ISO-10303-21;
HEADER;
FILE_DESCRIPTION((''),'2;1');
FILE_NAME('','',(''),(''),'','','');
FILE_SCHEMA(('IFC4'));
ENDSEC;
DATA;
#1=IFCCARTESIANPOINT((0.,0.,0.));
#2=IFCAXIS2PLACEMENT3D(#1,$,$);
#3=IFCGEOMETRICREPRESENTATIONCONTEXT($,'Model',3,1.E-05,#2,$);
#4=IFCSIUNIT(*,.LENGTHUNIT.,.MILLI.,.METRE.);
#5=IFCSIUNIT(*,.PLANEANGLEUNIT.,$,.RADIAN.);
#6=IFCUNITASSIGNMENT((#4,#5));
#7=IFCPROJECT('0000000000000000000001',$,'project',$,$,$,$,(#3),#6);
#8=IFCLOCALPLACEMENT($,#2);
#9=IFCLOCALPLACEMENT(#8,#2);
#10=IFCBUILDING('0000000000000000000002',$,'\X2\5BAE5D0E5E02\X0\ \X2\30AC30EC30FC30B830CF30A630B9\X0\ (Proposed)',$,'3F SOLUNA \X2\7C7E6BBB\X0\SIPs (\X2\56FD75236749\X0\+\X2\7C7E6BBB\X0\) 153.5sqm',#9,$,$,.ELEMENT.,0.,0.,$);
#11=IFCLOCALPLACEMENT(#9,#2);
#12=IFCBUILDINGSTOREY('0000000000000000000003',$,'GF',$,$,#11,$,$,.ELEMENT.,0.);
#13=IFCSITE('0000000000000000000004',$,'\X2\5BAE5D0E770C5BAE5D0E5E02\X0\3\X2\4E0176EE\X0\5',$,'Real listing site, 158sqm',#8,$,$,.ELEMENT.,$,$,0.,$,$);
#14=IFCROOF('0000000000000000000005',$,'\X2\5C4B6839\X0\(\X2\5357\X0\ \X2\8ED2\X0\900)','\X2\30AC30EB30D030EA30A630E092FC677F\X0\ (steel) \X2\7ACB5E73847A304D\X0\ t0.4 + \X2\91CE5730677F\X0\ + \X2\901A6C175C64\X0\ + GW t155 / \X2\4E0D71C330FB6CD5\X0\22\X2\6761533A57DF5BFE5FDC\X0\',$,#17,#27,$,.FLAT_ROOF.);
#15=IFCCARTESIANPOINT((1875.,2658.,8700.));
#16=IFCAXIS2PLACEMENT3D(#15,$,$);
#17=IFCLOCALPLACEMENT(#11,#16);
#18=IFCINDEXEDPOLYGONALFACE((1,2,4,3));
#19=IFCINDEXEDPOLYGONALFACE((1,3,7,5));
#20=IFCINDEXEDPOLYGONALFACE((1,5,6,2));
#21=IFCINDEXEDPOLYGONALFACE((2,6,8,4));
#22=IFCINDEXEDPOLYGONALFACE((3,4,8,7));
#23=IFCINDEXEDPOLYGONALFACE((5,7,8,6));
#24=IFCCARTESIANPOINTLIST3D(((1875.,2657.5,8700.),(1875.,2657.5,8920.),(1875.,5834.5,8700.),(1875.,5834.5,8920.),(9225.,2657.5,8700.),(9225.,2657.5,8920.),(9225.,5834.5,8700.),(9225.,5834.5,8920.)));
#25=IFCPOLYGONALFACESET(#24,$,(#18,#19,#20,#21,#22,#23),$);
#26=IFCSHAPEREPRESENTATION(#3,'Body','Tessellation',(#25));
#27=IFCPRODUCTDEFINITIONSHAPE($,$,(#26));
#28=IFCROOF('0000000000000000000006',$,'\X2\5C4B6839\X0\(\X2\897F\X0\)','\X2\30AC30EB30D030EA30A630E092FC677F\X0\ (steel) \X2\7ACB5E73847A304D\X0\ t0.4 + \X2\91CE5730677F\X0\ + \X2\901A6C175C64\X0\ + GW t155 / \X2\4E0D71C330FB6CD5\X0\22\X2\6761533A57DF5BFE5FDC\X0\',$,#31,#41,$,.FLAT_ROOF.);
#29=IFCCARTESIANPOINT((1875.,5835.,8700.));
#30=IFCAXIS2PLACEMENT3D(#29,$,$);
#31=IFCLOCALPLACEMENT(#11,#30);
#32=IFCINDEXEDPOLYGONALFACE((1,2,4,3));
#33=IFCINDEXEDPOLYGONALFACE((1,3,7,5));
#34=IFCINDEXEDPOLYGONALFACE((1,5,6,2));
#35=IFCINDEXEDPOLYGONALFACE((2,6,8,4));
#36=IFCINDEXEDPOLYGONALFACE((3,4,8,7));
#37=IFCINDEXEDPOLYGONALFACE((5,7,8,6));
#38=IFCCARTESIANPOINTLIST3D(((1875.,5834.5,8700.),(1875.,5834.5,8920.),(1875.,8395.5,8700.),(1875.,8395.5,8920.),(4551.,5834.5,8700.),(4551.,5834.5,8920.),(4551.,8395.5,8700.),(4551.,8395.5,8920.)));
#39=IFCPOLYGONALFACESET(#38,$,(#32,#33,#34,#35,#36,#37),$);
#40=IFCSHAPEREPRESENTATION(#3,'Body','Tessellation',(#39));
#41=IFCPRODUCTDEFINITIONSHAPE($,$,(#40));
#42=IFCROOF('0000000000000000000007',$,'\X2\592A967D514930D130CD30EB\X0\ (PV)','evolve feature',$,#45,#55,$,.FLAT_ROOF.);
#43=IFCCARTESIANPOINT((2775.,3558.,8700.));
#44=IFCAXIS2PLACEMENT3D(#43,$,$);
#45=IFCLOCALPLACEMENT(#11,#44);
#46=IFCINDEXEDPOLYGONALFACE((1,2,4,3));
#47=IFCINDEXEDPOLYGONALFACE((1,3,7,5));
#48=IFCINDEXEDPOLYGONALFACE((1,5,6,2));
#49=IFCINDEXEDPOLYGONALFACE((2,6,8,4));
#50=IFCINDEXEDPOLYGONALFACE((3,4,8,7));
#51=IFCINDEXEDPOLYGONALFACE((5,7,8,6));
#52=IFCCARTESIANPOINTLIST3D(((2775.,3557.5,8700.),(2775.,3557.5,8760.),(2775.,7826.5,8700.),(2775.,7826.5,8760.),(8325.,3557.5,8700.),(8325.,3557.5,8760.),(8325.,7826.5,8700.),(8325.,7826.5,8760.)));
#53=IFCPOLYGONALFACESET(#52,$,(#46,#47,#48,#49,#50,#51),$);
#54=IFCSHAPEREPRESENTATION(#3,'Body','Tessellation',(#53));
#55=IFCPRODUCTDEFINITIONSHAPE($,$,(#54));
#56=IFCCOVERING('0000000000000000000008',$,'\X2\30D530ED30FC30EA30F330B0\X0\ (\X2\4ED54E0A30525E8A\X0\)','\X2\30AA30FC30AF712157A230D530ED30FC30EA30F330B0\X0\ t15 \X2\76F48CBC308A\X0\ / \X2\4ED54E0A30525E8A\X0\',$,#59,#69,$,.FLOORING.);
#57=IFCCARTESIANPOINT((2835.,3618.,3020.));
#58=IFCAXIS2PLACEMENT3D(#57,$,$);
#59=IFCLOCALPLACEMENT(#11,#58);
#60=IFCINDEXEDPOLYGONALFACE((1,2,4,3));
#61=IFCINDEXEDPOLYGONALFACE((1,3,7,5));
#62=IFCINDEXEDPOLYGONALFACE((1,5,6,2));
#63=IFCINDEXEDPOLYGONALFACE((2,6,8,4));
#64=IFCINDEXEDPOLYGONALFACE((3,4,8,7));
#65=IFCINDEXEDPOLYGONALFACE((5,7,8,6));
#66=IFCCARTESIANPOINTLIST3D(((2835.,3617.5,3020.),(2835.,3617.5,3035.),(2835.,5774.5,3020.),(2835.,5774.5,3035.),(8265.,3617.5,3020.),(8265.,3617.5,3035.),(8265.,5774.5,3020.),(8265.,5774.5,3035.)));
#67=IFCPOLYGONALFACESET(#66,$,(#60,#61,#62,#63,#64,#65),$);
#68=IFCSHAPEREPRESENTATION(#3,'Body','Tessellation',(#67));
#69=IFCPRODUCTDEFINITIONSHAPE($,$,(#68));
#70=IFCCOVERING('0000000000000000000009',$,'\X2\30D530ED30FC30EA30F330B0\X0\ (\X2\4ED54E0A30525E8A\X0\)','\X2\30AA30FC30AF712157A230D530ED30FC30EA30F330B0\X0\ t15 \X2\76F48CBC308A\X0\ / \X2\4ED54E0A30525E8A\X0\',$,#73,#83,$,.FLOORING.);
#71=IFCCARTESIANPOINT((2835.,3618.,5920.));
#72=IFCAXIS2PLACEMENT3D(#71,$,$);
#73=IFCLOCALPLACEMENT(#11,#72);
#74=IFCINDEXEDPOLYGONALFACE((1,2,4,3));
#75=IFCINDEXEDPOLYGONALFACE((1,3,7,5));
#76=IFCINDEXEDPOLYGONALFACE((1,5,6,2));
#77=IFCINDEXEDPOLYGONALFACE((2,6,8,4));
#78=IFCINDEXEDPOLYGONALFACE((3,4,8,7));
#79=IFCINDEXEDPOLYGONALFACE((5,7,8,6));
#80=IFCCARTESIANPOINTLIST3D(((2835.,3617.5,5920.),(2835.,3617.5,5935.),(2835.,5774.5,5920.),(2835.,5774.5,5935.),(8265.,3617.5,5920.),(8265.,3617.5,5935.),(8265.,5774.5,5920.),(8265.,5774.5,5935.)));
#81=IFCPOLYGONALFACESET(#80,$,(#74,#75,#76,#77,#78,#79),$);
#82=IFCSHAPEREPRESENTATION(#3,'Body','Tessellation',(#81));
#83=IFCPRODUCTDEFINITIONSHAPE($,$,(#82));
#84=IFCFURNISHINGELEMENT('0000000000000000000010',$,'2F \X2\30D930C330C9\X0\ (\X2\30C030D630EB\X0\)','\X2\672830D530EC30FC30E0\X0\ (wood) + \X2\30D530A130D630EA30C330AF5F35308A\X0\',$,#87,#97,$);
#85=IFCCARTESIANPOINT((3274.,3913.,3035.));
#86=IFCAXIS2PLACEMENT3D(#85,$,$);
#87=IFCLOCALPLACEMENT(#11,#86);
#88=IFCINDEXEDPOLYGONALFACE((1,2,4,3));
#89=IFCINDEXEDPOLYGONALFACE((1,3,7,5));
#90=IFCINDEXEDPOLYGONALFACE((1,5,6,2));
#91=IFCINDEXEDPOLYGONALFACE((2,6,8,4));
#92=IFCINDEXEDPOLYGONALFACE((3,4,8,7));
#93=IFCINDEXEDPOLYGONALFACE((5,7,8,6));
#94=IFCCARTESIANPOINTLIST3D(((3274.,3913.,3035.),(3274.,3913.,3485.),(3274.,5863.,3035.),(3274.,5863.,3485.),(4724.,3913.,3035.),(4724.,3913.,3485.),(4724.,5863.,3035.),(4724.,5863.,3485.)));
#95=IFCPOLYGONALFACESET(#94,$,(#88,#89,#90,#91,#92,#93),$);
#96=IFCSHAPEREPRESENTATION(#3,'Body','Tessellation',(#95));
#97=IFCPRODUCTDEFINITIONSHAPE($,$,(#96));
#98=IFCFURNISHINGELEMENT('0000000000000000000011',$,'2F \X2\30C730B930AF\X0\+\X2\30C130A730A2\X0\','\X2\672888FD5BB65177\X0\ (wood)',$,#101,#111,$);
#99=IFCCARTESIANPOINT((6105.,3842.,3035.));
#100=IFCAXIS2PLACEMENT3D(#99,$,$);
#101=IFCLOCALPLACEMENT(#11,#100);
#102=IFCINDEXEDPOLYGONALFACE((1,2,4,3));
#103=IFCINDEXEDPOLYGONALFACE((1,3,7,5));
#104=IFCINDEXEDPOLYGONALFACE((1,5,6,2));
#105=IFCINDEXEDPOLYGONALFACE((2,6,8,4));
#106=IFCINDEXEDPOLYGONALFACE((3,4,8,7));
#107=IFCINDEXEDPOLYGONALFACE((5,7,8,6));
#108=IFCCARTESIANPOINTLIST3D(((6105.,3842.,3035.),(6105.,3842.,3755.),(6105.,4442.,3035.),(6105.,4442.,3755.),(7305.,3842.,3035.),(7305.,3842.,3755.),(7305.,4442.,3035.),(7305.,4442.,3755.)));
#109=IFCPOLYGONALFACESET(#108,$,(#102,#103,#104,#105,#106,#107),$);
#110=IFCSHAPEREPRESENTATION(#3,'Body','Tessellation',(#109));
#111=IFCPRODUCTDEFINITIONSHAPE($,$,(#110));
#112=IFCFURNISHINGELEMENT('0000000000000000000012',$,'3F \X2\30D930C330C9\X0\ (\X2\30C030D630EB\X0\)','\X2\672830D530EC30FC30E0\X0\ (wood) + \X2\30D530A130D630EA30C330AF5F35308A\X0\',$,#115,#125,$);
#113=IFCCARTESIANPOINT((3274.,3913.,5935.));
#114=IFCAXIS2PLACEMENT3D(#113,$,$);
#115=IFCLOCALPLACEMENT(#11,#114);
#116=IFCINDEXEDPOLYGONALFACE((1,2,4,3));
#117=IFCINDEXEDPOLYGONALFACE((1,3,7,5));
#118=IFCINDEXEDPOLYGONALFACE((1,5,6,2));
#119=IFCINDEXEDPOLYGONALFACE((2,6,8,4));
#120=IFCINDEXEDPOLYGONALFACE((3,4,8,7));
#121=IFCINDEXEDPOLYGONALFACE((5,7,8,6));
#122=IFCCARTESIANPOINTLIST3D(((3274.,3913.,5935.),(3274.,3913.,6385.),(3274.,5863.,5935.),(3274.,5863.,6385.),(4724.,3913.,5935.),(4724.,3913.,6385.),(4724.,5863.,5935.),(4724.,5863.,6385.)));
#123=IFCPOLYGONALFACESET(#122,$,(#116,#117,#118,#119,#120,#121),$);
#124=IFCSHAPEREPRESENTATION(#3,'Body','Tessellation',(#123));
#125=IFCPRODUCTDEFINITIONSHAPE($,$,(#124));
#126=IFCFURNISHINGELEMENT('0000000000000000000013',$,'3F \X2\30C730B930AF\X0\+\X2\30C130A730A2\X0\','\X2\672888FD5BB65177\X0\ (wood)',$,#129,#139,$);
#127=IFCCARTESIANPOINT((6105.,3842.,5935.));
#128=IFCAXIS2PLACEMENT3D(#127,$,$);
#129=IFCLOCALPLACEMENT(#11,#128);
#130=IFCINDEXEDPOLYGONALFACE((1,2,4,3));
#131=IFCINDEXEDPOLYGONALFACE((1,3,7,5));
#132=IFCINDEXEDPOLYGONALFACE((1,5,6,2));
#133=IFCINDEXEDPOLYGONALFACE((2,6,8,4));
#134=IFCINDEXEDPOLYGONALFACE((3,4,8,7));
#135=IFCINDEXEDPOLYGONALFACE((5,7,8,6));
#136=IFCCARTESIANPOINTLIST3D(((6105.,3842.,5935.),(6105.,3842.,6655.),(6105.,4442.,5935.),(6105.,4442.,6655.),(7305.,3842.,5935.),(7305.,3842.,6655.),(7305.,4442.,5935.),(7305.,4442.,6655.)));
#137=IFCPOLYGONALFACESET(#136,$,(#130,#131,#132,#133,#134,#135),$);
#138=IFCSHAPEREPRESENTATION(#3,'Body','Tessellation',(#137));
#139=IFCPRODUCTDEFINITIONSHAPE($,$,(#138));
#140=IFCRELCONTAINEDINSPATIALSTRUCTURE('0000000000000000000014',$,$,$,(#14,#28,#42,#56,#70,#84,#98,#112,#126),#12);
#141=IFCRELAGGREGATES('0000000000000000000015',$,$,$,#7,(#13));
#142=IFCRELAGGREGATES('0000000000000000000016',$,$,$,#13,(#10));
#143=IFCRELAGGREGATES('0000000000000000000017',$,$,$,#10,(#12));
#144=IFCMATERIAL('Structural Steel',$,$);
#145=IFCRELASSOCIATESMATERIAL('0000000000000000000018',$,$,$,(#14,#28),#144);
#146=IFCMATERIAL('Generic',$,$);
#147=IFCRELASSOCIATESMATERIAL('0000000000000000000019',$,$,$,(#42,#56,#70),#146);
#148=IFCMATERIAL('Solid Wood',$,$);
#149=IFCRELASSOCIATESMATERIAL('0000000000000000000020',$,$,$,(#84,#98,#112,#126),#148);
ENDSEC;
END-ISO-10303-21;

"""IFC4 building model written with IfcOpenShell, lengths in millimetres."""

from ifc_helpers import new_model, si_unit, frame, frame_2d, origin, place, context, project, spatial, rectangle, extrude, material, element, save


model = new_model("IFC4")

# Units and contexts
model_context = context("Model", 3, precision=1e-05, world=origin())
ifc_project = project(units=[si_unit("LENGTHUNIT", "METRE", prefix="MILLI"), si_unit("PLANEANGLEUNIT", "RADIAN")], contexts=[model_context])

# Site, building, storey
site_placement = place(None, origin())
site = spatial("IfcSite", under=ifc_project, at=site_placement, Name="宮崎県宮崎市3丁目5", ObjectType="Real listing site, 158sqm", CompositionType="ELEMENT", RefElevation=0.0)
building_placement = place(site_placement, origin())
building = spatial("IfcBuilding", under=site, at=building_placement, Name="宮崎市 ガレージハウス (Proposed)", ObjectType="3F SOLUNA 籾殻SIPs (国産杉+籾殻) 153.5sqm", CompositionType="ELEMENT", ElevationOfRefHeight=0.0, ElevationOfTerrain=0.0)
storey_placement = place(building_placement, origin())
storey = spatial("IfcBuildingStorey", under=building, at=storey_placement, Name="GF", CompositionType="ELEMENT", Elevation=0.0)

# Shared definitions
ifc_material_1 = material(Name="Solid Wood")

# Roofs
ifc_material_2 = material(Name="Structural Steel")
roof_1_placement = place(storey_placement, frame((1875.0, 2658.0, 8700.0)))
element("IfcRoof", 1, at=roof_1_placement, inside=storey, material=ifc_material_2, Name="屋根(南 軒900)", Description="ガルバリウム鋼板 (steel) 立平葺き t0.4 + 野地板 + 通気層 + GW t155 / 不燃・法22条区域対応", PredefinedType="FLAT_ROOF", context=model_context, shape_type="SweptSolid", body=[
    extrude(rectangle(XDim=7350.0, YDim=3177.0, at=frame_2d((3675.0, 1588.0))), frame((1875.0, 2658.0, 8700.0)), (0.0, 0.0, 1.0), 220.0),
])
roof_2_placement = place(storey_placement, frame((1875.0, 5835.0, 8700.0)))
element("IfcRoof", 2, at=roof_2_placement, inside=storey, material=ifc_material_2, Name="屋根(西)", Description="ガルバリウム鋼板 (steel) 立平葺き t0.4 + 野地板 + 通気層 + GW t155 / 不燃・法22条区域対応", PredefinedType="FLAT_ROOF", context=model_context, shape_type="SweptSolid", body=[
    extrude(rectangle(XDim=2676.0, YDim=2561.0, at=frame_2d((1338.0, 1280.0))), frame((1875.0, 5835.0, 8700.0)), (0.0, 0.0, 1.0), 220.0),
])
ifc_material_3 = material(Name="Generic")
roof_3_placement = place(storey_placement, frame((2775.0, 3558.0, 8700.0)))
element("IfcRoof", 3, at=roof_3_placement, inside=storey, material=ifc_material_3, Name="太陽光パネル (PV)", Description="evolve feature", PredefinedType="FLAT_ROOF", context=model_context, shape_type="SweptSolid", body=[
    extrude(rectangle(XDim=5550.0, YDim=4269.0, at=frame_2d((2775.0, 2134.0))), frame((2775.0, 3558.0, 8700.0)), (0.0, 0.0, 1.0), 60.0),
])

# Coverings
covering_1_placement = place(storey_placement, frame((2835.0, 3618.0, 3020.0)))
element("IfcCovering", 4, at=covering_1_placement, inside=storey, material=ifc_material_3, Name="フローリング (仕上げ床)", Description="オーク無垢フローリング t15 直貼り / 仕上げ床", PredefinedType="FLOORING", context=model_context, shape_type="SweptSolid", body=[
    extrude(rectangle(XDim=5430.0, YDim=2157.0, at=frame_2d((2715.0, 1078.0))), frame((2835.0, 3618.0, 3020.0)), (0.0, 0.0, 1.0), 15.0),
])
covering_2_placement = place(storey_placement, frame((2835.0, 3618.0, 5920.0)))
element("IfcCovering", 5, at=covering_2_placement, inside=storey, material=ifc_material_3, Name="フローリング (仕上げ床)", Description="オーク無垢フローリング t15 直貼り / 仕上げ床", PredefinedType="FLOORING", context=model_context, shape_type="SweptSolid", body=[
    extrude(rectangle(XDim=5430.0, YDim=2157.0, at=frame_2d((2715.0, 1078.0))), frame((2835.0, 3618.0, 5920.0)), (0.0, 0.0, 1.0), 15.0),
])

# Furnishing elements
furnishing_1_placement = place(storey_placement, frame((3274.0, 3913.0, 3035.0)))
element("IfcFurnishingElement", 6, at=furnishing_1_placement, inside=storey, material=ifc_material_1, Name="2F ベッド (ダブル)", Description="木フレーム (wood) + ファブリック張り", context=model_context, shape_type="SweptSolid", body=[
    extrude(rectangle(XDim=1450.0, YDim=1950.0, at=frame_2d((725.0, 975.0))), frame((3274.0, 3913.0, 3035.0)), (0.0, 0.0, 1.0), 450.0),
])
furnishing_2_placement = place(storey_placement, frame((6105.0, 3842.0, 3035.0)))
element("IfcFurnishingElement", 7, at=furnishing_2_placement, inside=storey, material=ifc_material_1, Name="2F デスク+チェア", Description="木製家具 (wood)", context=model_context, shape_type="SweptSolid", body=[
    extrude(rectangle(XDim=1200.0, YDim=600.0, at=frame_2d((600.0, 300.0))), frame((6105.0, 3842.0, 3035.0)), (0.0, 0.0, 1.0), 720.0),
])
furnishing_3_placement = place(storey_placement, frame((3274.0, 3913.0, 5935.0)))
element("IfcFurnishingElement", 8, at=furnishing_3_placement, inside=storey, material=ifc_material_1, Name="3F ベッド (ダブル)", Description="木フレーム (wood) + ファブリック張り", context=model_context, shape_type="SweptSolid", body=[
    extrude(rectangle(XDim=1450.0, YDim=1950.0, at=frame_2d((725.0, 975.0))), frame((3274.0, 3913.0, 5935.0)), (0.0, 0.0, 1.0), 450.0),
])
furnishing_4_placement = place(storey_placement, frame((6105.0, 3842.0, 5935.0)))
element("IfcFurnishingElement", 9, at=furnishing_4_placement, inside=storey, material=ifc_material_1, Name="3F デスク+チェア", Description="木製家具 (wood)", context=model_context, shape_type="SweptSolid", body=[
    extrude(rectangle(XDim=1200.0, YDim=600.0, at=frame_2d((600.0, 300.0))), frame((6105.0, 3842.0, 5935.0)), (0.0, 0.0, 1.0), 720.0),
])

save(model, "model.ifc")
